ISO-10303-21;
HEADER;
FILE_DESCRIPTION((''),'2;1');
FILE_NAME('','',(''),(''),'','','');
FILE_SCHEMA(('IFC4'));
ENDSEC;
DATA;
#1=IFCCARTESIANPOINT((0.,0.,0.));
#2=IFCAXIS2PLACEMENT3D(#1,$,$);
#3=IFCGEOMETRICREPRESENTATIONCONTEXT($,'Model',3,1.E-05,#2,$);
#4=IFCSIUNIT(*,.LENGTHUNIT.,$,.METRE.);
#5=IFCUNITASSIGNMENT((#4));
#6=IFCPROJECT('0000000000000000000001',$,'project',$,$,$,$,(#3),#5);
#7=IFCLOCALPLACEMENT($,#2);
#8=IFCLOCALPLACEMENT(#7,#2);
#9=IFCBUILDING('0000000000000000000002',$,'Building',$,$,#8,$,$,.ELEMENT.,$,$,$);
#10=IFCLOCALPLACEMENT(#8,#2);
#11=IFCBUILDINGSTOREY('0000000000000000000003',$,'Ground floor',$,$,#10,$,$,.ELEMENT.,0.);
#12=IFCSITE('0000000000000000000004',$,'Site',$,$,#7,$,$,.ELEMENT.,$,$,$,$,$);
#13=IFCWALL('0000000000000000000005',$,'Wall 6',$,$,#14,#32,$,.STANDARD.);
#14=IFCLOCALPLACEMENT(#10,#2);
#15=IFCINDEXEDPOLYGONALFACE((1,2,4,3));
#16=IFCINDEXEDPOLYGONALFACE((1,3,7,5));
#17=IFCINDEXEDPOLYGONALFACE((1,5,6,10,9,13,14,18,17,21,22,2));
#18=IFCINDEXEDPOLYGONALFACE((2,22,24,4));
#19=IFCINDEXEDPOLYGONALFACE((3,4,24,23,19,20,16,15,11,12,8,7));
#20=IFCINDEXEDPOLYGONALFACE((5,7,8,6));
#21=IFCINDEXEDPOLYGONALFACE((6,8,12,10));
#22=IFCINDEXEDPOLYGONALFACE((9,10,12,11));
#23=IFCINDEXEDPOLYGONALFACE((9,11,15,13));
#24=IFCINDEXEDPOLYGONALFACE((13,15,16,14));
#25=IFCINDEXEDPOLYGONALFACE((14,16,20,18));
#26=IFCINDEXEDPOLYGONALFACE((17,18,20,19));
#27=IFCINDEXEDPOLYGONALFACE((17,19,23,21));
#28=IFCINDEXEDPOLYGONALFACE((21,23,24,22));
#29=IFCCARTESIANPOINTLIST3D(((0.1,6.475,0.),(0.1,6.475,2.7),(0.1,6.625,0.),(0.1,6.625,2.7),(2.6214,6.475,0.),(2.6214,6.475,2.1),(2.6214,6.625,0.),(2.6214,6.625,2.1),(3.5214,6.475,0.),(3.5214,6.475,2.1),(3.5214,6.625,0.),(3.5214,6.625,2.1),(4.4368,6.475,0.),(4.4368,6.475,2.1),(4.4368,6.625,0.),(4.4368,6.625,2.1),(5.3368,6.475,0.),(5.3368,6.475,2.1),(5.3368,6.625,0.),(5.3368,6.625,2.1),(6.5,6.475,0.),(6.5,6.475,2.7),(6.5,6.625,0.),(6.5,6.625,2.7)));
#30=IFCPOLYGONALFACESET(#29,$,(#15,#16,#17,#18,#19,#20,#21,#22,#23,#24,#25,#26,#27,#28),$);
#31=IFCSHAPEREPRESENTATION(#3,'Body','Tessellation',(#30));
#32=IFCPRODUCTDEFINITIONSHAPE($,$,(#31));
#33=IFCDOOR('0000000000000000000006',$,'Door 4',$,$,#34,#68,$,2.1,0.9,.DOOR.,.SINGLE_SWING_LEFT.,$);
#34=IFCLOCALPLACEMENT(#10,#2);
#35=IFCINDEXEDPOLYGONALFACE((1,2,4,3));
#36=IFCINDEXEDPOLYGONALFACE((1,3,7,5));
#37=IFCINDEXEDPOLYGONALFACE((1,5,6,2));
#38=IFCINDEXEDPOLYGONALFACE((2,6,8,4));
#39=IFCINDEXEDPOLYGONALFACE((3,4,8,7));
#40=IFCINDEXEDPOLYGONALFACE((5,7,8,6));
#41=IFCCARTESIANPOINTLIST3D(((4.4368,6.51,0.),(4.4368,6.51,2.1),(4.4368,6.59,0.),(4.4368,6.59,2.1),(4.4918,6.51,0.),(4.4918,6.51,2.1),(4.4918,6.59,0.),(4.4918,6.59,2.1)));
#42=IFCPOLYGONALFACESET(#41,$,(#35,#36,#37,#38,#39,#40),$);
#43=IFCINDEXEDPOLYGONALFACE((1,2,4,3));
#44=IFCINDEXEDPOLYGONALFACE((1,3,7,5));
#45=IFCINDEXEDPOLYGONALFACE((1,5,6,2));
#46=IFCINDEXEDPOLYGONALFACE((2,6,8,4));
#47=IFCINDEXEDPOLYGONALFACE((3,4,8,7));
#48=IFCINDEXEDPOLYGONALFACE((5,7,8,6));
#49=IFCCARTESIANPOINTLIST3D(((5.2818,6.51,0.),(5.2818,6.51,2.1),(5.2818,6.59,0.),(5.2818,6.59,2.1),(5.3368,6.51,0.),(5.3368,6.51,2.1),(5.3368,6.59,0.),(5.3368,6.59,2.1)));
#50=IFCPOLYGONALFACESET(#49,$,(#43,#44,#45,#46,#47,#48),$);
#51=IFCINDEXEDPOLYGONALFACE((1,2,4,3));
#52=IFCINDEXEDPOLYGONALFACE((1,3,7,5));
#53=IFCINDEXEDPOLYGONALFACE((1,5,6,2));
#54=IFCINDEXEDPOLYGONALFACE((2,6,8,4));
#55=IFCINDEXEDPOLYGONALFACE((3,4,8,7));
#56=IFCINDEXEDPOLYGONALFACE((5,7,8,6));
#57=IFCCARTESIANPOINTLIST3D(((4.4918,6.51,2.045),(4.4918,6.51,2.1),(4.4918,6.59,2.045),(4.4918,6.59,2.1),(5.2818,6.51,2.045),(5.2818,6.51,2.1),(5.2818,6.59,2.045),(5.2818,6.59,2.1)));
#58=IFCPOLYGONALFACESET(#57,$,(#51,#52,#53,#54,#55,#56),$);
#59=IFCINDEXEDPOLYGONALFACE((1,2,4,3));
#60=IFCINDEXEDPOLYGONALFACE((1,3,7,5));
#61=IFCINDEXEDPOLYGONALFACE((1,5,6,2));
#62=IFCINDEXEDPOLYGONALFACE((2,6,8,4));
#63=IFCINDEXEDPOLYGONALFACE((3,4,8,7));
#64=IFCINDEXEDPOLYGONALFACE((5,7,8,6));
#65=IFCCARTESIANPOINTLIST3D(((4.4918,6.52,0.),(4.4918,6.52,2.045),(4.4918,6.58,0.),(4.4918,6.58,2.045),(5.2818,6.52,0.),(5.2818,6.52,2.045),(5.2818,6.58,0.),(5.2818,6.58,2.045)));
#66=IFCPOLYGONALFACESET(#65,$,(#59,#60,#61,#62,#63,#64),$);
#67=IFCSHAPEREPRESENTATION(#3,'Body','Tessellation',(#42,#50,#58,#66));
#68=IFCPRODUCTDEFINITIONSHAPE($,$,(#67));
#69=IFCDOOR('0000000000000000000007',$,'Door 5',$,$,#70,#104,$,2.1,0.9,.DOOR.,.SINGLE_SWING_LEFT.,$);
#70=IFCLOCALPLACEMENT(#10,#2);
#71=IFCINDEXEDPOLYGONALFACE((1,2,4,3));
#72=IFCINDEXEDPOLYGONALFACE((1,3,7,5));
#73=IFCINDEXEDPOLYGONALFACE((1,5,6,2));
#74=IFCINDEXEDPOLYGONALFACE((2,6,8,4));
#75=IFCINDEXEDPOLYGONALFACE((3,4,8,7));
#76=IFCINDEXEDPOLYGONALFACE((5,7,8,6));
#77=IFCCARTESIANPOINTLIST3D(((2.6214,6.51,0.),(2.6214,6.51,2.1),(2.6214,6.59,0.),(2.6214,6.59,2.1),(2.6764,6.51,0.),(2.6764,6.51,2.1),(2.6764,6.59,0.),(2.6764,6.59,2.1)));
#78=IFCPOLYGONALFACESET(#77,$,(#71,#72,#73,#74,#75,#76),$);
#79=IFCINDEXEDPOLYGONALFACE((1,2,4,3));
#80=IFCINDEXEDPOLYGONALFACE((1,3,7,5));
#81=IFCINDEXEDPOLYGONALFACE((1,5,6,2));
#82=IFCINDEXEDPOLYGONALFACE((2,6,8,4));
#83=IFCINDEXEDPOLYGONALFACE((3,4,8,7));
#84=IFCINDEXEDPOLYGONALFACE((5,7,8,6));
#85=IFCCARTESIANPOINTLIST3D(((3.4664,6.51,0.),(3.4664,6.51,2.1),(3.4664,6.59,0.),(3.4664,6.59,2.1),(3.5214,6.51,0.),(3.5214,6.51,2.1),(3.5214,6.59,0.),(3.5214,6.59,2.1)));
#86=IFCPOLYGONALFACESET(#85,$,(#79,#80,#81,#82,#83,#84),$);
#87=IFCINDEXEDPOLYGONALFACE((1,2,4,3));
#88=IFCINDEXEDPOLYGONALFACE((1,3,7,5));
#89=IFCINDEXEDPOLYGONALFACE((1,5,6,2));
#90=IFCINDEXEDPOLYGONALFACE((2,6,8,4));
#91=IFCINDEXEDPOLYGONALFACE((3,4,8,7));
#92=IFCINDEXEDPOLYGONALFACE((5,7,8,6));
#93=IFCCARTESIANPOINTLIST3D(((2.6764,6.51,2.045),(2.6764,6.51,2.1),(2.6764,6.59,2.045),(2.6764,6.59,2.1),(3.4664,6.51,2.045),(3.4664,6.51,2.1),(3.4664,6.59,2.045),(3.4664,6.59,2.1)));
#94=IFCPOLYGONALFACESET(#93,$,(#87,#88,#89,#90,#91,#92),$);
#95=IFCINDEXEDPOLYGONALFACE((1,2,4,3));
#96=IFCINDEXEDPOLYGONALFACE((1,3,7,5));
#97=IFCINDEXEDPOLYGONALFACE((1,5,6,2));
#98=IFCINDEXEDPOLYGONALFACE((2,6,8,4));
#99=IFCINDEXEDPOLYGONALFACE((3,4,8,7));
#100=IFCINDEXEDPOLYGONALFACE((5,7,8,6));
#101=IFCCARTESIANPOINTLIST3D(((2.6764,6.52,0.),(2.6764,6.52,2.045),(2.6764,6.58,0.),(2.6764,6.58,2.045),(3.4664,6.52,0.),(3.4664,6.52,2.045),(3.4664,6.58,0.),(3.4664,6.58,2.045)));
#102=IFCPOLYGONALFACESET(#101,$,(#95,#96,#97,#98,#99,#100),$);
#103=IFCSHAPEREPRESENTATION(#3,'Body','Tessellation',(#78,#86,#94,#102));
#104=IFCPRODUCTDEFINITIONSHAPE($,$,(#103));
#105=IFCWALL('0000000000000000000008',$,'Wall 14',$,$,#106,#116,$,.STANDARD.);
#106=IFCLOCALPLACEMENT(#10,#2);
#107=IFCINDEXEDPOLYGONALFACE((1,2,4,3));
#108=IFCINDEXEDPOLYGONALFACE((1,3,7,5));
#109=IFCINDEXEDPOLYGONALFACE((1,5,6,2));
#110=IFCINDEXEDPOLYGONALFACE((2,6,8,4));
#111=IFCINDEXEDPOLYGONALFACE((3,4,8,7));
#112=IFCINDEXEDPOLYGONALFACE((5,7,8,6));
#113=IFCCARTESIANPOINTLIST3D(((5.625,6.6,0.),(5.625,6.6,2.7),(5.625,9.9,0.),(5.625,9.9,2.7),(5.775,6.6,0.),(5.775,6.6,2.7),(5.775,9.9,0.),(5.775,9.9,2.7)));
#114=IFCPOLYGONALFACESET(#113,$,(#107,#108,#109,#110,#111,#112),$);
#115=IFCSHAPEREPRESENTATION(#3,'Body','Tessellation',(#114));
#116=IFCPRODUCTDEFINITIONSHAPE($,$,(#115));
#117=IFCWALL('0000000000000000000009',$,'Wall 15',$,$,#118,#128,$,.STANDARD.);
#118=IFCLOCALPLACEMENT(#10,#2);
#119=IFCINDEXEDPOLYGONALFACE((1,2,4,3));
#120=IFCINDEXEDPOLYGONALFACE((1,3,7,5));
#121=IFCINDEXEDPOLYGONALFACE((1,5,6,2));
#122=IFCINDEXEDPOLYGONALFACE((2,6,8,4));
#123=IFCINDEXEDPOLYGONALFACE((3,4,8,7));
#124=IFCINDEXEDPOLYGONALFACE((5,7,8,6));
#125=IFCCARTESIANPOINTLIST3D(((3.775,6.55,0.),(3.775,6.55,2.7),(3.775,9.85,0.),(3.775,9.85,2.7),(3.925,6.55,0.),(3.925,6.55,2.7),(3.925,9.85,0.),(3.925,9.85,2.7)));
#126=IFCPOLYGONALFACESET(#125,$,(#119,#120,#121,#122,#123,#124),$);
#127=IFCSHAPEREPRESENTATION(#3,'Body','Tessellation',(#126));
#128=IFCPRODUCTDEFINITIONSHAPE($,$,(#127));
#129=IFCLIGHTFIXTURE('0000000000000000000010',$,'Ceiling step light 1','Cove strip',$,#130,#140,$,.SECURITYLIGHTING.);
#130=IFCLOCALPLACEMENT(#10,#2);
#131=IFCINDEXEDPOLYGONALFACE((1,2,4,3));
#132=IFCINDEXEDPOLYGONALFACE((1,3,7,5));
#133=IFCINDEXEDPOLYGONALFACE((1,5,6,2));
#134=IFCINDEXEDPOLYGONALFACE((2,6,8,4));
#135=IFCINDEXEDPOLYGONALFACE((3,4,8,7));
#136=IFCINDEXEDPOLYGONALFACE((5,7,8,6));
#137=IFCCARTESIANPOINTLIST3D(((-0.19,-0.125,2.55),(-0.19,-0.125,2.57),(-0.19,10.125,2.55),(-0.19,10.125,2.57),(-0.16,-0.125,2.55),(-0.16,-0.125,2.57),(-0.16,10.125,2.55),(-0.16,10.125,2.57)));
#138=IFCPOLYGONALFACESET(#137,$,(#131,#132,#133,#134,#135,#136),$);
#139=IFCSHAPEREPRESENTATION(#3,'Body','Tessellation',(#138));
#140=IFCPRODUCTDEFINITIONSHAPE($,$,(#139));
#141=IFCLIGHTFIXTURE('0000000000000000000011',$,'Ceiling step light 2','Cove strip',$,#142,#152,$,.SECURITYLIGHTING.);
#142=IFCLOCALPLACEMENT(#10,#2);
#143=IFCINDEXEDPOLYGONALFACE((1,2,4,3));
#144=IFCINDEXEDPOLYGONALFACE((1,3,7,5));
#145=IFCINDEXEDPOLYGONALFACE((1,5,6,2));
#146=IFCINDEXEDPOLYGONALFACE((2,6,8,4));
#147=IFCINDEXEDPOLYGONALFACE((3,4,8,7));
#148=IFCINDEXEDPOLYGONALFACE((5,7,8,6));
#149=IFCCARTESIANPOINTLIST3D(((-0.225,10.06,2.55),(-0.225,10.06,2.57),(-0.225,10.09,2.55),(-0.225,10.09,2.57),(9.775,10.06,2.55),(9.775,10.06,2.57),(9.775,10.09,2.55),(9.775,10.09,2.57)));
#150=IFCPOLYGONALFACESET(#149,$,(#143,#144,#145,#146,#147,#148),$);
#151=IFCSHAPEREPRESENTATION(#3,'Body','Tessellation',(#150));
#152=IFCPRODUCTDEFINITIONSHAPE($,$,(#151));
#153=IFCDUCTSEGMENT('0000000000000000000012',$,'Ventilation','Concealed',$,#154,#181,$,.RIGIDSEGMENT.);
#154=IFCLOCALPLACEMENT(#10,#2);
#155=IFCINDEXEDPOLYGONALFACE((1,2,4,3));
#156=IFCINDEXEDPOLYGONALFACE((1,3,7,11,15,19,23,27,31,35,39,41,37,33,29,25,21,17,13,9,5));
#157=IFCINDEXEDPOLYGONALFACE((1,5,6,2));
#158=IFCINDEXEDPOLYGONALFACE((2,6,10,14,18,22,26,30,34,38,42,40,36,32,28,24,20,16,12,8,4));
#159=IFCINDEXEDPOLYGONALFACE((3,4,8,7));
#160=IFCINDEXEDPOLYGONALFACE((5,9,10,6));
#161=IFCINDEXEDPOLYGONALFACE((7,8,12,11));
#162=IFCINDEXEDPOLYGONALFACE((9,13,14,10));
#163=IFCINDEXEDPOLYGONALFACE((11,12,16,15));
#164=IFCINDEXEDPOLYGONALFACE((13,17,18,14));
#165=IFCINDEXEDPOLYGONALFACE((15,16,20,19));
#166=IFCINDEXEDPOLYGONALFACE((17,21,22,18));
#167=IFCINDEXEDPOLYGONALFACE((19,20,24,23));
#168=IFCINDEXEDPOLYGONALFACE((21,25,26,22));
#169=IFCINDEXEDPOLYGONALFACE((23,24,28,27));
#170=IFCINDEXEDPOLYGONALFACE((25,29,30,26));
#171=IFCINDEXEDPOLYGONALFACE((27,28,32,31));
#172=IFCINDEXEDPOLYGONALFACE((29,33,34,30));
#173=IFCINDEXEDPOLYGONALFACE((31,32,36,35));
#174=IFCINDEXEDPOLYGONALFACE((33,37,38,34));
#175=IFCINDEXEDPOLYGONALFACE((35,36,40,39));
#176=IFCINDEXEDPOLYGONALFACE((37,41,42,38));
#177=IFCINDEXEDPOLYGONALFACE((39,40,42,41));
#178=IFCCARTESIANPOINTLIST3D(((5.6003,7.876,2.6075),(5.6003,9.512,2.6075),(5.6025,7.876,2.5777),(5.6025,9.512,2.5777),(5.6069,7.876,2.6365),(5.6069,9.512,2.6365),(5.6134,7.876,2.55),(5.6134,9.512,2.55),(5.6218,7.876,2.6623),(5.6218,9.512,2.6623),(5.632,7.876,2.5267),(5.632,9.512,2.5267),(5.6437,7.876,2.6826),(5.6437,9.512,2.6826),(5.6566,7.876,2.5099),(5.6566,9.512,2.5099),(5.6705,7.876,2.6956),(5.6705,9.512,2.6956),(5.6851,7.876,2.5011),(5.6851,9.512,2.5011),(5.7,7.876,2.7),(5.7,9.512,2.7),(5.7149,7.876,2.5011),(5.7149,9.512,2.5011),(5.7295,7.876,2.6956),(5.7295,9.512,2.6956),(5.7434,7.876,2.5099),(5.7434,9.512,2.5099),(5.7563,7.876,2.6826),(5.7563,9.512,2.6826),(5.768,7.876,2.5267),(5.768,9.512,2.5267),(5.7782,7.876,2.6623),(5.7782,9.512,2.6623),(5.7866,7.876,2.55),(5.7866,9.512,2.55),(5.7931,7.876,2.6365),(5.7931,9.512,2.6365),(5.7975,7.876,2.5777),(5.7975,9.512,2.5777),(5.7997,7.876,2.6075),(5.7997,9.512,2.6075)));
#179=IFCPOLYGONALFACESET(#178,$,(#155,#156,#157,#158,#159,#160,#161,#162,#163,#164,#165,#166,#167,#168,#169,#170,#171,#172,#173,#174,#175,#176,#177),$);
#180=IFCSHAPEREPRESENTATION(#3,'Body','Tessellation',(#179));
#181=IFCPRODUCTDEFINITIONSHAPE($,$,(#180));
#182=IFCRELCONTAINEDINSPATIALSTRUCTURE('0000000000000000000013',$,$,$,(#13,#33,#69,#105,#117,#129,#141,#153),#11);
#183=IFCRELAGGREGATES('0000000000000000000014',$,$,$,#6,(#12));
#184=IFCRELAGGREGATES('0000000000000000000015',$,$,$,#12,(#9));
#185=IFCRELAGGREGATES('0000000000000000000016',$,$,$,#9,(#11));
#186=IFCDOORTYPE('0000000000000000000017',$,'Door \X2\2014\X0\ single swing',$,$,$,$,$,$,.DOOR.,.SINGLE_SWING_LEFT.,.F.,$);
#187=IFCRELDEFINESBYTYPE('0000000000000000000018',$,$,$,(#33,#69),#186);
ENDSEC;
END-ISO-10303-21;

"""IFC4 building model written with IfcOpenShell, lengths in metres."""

from ifc_helpers import new_model, si_unit, frame, frame_2d, origin, origin_2d, place, context, project, spatial, rectangle, circle, extrude, type_object, element, fill, save


model = new_model("IFC4")

# Units and contexts
model_context = context("Model", 3, precision=1e-05, world=origin())
ifc_project = project(units=[si_unit("LENGTHUNIT", "METRE")], contexts=[model_context])

# Site, building, storey
site_placement = place(None, origin())
site = spatial("IfcSite", under=ifc_project, at=site_placement, Name="Site", CompositionType="ELEMENT")
building_placement = place(site_placement, origin())
building = spatial("IfcBuilding", under=site, at=building_placement, Name="Building", CompositionType="ELEMENT")
storey_placement = place(building_placement, origin())
storey = spatial("IfcBuildingStorey", under=building, at=storey_placement, Name="Ground floor", CompositionType="ELEMENT", Elevation=0.0)

# Wall, openings, doors
wall_placement = place(storey_placement, frame((0.1, 6.55, 0.0), z_axis=(0.0, 0.0, 1.0), x_axis=(1.0, 0.0, 0.0)))
wall = element("IfcWall", 1, at=wall_placement, inside=storey, Name="Wall 6", PredefinedType="STANDARD", context=model_context, shape_type="SweptSolid", body=[
    extrude(rectangle(XDim=6.4, YDim=0.15, at=frame_2d((3.2, 0.0))), origin(), (0.0, 0.0, 1.0), 2.7),
])
opening_1_placement = place(storey_placement, frame((4.4367, 6.55, 0.0), z_axis=(0.0, 0.0, 1.0), x_axis=(1.0, 0.0, 0.0)))
opening_1 = element("IfcOpeningElement", 2, at=opening_1_placement, cuts=wall, PredefinedType="OPENING", context=model_context, shape_type="SweptSolid", body=[
    extrude(rectangle(XDim=0.9, YDim=0.21, at=frame_2d((0.45, 0.0))), origin(), (0.0, 0.0, 1.0), 2.1),
])
opening_2_placement = place(storey_placement, frame((2.6214, 6.55, 0.0), z_axis=(0.0, 0.0, 1.0), x_axis=(1.0, 0.0, 0.0)))
opening_2 = element("IfcOpeningElement", 3, at=opening_2_placement, cuts=wall, PredefinedType="OPENING", context=model_context, shape_type="SweptSolid", body=[
    extrude(rectangle(XDim=0.9, YDim=0.21, at=frame_2d((0.45, 0.0))), origin(), (0.0, 0.0, 1.0), 2.1),
])
door_type = type_object("IfcDoorType", Name="Door — single swing", OperationType="SINGLE_SWING_LEFT", ParameterTakesPrecedence=False, PredefinedType="DOOR")
door_1_placement = place(storey_placement, frame((4.4367, 6.55, 0.0), z_axis=(0.0, 0.0, 1.0), x_axis=(1.0, 0.0, 0.0)))
door_1 = element("IfcDoor", 4, at=door_1_placement, inside=storey, type_object=door_type, Name="Door 4", OperationType="SINGLE_SWING_LEFT", OverallHeight=2.1, OverallWidth=0.9, PredefinedType="DOOR", context=model_context, shape_type="SweptSolid", body=[
    extrude(rectangle(XDim=0.055, YDim=0.08, at=frame_2d((0.0275, 0.0))), origin(), (0.0, 0.0, 1.0), 2.1),
    extrude(rectangle(XDim=0.055, YDim=0.08, at=frame_2d((0.8725, 0.0))), origin(), (0.0, 0.0, 1.0), 2.1),
    extrude(rectangle(XDim=0.79, YDim=0.08, at=frame_2d((0.45, 0.0))), frame((0.0, 0.0, 2.045)), (0.0, 0.0, 1.0), 0.055),
    extrude(rectangle(XDim=0.79, YDim=0.06, at=frame_2d((0.45, 0.0))), origin(), (0.0, 0.0, 1.0), 2.045),
])
fill(opening_1, door_1)
door_2_placement = place(storey_placement, frame((2.6214, 6.55, 0.0), z_axis=(0.0, 0.0, 1.0), x_axis=(1.0, 0.0, 0.0)))
door_2 = element("IfcDoor", 5, at=door_2_placement, inside=storey, type_object=door_type, Name="Door 5", OperationType="SINGLE_SWING_LEFT", OverallHeight=2.1, OverallWidth=0.9, PredefinedType="DOOR", context=model_context, shape_type="SweptSolid", body=[
    extrude(rectangle(XDim=0.055, YDim=0.08, at=frame_2d((0.0275, 0.0))), origin(), (0.0, 0.0, 1.0), 2.1),
    extrude(rectangle(XDim=0.055, YDim=0.08, at=frame_2d((0.8725, 0.0))), origin(), (0.0, 0.0, 1.0), 2.1),
    extrude(rectangle(XDim=0.79, YDim=0.08, at=frame_2d((0.45, 0.0))), frame((0.0, 0.0, 2.045)), (0.0, 0.0, 1.0), 0.055),
    extrude(rectangle(XDim=0.79, YDim=0.06, at=frame_2d((0.45, 0.0))), origin(), (0.0, 0.0, 1.0), 2.045),
])
fill(opening_2, door_2)

# Walls
for number, where, z_axis, x_axis, name in (
    (6, (5.7, 9.9, 0.0), (0.0, 0.0, 1.0), (0.0, -1.0, 0.0), "Wall 14"),
    (7, (3.85, 9.85, 0.0), (0.0, 0.0, 1.0), (0.0, -1.0, 0.0), "Wall 15"),
):
    element("IfcWall", number, at=place(storey_placement, frame(where, z_axis=z_axis, x_axis=x_axis)), inside=storey, Name=name, PredefinedType="STANDARD", context=model_context, shape_type="SweptSolid", body=[
        extrude(rectangle(XDim=3.3, YDim=0.15, at=frame_2d((1.65, 0.0))), origin(), (0.0, 0.0, 1.0), 2.7),
    ])

# Light fixtures
light_fixture_1_placement = place(storey_placement, frame((-0.175, 5.0, 2.55), z_axis=(0.0, 0.0, 1.0), x_axis=(0.0, 1.0, 0.0)))
element("IfcLightFixture", 8, at=light_fixture_1_placement, inside=storey, Name="Ceiling step light 1", Description="Cove strip", PredefinedType="SECURITYLIGHTING", context=model_context, shape_type="SweptSolid", body=[
    extrude(rectangle(XDim=10.25, YDim=0.03, at=origin_2d()), origin(), (0.0, 0.0, 1.0), 0.02),
])
light_fixture_2_placement = place(storey_placement, frame((4.775, 10.075, 2.55), z_axis=(0.0, 0.0, 1.0), x_axis=(1.0, 0.0, 0.0)))
element("IfcLightFixture", 9, at=light_fixture_2_placement, inside=storey, Name="Ceiling step light 2", Description="Cove strip", PredefinedType="SECURITYLIGHTING", context=model_context, shape_type="SweptSolid", body=[
    extrude(rectangle(XDim=10.0, YDim=0.03, at=origin_2d()), origin(), (0.0, 0.0, 1.0), 0.02),
])

# Duct segment
duct_segment_placement = place(storey_placement, frame((5.7, 9.512, 2.6), z_axis=(0.0, -1.0, 0.0), x_axis=(0.0, 0.0, 1.0)))
element("IfcDuctSegment", 10, at=duct_segment_placement, inside=storey, Name="Ventilation", Description="Concealed", PredefinedType="RIGIDSEGMENT", context=model_context, shape_type="SweptSolid", body=[
    extrude(circle(Radius=0.1, at=origin_2d()), origin(), (0.0, 0.0, 1.0), 1.636),
])

save(model, "model.ifc")
